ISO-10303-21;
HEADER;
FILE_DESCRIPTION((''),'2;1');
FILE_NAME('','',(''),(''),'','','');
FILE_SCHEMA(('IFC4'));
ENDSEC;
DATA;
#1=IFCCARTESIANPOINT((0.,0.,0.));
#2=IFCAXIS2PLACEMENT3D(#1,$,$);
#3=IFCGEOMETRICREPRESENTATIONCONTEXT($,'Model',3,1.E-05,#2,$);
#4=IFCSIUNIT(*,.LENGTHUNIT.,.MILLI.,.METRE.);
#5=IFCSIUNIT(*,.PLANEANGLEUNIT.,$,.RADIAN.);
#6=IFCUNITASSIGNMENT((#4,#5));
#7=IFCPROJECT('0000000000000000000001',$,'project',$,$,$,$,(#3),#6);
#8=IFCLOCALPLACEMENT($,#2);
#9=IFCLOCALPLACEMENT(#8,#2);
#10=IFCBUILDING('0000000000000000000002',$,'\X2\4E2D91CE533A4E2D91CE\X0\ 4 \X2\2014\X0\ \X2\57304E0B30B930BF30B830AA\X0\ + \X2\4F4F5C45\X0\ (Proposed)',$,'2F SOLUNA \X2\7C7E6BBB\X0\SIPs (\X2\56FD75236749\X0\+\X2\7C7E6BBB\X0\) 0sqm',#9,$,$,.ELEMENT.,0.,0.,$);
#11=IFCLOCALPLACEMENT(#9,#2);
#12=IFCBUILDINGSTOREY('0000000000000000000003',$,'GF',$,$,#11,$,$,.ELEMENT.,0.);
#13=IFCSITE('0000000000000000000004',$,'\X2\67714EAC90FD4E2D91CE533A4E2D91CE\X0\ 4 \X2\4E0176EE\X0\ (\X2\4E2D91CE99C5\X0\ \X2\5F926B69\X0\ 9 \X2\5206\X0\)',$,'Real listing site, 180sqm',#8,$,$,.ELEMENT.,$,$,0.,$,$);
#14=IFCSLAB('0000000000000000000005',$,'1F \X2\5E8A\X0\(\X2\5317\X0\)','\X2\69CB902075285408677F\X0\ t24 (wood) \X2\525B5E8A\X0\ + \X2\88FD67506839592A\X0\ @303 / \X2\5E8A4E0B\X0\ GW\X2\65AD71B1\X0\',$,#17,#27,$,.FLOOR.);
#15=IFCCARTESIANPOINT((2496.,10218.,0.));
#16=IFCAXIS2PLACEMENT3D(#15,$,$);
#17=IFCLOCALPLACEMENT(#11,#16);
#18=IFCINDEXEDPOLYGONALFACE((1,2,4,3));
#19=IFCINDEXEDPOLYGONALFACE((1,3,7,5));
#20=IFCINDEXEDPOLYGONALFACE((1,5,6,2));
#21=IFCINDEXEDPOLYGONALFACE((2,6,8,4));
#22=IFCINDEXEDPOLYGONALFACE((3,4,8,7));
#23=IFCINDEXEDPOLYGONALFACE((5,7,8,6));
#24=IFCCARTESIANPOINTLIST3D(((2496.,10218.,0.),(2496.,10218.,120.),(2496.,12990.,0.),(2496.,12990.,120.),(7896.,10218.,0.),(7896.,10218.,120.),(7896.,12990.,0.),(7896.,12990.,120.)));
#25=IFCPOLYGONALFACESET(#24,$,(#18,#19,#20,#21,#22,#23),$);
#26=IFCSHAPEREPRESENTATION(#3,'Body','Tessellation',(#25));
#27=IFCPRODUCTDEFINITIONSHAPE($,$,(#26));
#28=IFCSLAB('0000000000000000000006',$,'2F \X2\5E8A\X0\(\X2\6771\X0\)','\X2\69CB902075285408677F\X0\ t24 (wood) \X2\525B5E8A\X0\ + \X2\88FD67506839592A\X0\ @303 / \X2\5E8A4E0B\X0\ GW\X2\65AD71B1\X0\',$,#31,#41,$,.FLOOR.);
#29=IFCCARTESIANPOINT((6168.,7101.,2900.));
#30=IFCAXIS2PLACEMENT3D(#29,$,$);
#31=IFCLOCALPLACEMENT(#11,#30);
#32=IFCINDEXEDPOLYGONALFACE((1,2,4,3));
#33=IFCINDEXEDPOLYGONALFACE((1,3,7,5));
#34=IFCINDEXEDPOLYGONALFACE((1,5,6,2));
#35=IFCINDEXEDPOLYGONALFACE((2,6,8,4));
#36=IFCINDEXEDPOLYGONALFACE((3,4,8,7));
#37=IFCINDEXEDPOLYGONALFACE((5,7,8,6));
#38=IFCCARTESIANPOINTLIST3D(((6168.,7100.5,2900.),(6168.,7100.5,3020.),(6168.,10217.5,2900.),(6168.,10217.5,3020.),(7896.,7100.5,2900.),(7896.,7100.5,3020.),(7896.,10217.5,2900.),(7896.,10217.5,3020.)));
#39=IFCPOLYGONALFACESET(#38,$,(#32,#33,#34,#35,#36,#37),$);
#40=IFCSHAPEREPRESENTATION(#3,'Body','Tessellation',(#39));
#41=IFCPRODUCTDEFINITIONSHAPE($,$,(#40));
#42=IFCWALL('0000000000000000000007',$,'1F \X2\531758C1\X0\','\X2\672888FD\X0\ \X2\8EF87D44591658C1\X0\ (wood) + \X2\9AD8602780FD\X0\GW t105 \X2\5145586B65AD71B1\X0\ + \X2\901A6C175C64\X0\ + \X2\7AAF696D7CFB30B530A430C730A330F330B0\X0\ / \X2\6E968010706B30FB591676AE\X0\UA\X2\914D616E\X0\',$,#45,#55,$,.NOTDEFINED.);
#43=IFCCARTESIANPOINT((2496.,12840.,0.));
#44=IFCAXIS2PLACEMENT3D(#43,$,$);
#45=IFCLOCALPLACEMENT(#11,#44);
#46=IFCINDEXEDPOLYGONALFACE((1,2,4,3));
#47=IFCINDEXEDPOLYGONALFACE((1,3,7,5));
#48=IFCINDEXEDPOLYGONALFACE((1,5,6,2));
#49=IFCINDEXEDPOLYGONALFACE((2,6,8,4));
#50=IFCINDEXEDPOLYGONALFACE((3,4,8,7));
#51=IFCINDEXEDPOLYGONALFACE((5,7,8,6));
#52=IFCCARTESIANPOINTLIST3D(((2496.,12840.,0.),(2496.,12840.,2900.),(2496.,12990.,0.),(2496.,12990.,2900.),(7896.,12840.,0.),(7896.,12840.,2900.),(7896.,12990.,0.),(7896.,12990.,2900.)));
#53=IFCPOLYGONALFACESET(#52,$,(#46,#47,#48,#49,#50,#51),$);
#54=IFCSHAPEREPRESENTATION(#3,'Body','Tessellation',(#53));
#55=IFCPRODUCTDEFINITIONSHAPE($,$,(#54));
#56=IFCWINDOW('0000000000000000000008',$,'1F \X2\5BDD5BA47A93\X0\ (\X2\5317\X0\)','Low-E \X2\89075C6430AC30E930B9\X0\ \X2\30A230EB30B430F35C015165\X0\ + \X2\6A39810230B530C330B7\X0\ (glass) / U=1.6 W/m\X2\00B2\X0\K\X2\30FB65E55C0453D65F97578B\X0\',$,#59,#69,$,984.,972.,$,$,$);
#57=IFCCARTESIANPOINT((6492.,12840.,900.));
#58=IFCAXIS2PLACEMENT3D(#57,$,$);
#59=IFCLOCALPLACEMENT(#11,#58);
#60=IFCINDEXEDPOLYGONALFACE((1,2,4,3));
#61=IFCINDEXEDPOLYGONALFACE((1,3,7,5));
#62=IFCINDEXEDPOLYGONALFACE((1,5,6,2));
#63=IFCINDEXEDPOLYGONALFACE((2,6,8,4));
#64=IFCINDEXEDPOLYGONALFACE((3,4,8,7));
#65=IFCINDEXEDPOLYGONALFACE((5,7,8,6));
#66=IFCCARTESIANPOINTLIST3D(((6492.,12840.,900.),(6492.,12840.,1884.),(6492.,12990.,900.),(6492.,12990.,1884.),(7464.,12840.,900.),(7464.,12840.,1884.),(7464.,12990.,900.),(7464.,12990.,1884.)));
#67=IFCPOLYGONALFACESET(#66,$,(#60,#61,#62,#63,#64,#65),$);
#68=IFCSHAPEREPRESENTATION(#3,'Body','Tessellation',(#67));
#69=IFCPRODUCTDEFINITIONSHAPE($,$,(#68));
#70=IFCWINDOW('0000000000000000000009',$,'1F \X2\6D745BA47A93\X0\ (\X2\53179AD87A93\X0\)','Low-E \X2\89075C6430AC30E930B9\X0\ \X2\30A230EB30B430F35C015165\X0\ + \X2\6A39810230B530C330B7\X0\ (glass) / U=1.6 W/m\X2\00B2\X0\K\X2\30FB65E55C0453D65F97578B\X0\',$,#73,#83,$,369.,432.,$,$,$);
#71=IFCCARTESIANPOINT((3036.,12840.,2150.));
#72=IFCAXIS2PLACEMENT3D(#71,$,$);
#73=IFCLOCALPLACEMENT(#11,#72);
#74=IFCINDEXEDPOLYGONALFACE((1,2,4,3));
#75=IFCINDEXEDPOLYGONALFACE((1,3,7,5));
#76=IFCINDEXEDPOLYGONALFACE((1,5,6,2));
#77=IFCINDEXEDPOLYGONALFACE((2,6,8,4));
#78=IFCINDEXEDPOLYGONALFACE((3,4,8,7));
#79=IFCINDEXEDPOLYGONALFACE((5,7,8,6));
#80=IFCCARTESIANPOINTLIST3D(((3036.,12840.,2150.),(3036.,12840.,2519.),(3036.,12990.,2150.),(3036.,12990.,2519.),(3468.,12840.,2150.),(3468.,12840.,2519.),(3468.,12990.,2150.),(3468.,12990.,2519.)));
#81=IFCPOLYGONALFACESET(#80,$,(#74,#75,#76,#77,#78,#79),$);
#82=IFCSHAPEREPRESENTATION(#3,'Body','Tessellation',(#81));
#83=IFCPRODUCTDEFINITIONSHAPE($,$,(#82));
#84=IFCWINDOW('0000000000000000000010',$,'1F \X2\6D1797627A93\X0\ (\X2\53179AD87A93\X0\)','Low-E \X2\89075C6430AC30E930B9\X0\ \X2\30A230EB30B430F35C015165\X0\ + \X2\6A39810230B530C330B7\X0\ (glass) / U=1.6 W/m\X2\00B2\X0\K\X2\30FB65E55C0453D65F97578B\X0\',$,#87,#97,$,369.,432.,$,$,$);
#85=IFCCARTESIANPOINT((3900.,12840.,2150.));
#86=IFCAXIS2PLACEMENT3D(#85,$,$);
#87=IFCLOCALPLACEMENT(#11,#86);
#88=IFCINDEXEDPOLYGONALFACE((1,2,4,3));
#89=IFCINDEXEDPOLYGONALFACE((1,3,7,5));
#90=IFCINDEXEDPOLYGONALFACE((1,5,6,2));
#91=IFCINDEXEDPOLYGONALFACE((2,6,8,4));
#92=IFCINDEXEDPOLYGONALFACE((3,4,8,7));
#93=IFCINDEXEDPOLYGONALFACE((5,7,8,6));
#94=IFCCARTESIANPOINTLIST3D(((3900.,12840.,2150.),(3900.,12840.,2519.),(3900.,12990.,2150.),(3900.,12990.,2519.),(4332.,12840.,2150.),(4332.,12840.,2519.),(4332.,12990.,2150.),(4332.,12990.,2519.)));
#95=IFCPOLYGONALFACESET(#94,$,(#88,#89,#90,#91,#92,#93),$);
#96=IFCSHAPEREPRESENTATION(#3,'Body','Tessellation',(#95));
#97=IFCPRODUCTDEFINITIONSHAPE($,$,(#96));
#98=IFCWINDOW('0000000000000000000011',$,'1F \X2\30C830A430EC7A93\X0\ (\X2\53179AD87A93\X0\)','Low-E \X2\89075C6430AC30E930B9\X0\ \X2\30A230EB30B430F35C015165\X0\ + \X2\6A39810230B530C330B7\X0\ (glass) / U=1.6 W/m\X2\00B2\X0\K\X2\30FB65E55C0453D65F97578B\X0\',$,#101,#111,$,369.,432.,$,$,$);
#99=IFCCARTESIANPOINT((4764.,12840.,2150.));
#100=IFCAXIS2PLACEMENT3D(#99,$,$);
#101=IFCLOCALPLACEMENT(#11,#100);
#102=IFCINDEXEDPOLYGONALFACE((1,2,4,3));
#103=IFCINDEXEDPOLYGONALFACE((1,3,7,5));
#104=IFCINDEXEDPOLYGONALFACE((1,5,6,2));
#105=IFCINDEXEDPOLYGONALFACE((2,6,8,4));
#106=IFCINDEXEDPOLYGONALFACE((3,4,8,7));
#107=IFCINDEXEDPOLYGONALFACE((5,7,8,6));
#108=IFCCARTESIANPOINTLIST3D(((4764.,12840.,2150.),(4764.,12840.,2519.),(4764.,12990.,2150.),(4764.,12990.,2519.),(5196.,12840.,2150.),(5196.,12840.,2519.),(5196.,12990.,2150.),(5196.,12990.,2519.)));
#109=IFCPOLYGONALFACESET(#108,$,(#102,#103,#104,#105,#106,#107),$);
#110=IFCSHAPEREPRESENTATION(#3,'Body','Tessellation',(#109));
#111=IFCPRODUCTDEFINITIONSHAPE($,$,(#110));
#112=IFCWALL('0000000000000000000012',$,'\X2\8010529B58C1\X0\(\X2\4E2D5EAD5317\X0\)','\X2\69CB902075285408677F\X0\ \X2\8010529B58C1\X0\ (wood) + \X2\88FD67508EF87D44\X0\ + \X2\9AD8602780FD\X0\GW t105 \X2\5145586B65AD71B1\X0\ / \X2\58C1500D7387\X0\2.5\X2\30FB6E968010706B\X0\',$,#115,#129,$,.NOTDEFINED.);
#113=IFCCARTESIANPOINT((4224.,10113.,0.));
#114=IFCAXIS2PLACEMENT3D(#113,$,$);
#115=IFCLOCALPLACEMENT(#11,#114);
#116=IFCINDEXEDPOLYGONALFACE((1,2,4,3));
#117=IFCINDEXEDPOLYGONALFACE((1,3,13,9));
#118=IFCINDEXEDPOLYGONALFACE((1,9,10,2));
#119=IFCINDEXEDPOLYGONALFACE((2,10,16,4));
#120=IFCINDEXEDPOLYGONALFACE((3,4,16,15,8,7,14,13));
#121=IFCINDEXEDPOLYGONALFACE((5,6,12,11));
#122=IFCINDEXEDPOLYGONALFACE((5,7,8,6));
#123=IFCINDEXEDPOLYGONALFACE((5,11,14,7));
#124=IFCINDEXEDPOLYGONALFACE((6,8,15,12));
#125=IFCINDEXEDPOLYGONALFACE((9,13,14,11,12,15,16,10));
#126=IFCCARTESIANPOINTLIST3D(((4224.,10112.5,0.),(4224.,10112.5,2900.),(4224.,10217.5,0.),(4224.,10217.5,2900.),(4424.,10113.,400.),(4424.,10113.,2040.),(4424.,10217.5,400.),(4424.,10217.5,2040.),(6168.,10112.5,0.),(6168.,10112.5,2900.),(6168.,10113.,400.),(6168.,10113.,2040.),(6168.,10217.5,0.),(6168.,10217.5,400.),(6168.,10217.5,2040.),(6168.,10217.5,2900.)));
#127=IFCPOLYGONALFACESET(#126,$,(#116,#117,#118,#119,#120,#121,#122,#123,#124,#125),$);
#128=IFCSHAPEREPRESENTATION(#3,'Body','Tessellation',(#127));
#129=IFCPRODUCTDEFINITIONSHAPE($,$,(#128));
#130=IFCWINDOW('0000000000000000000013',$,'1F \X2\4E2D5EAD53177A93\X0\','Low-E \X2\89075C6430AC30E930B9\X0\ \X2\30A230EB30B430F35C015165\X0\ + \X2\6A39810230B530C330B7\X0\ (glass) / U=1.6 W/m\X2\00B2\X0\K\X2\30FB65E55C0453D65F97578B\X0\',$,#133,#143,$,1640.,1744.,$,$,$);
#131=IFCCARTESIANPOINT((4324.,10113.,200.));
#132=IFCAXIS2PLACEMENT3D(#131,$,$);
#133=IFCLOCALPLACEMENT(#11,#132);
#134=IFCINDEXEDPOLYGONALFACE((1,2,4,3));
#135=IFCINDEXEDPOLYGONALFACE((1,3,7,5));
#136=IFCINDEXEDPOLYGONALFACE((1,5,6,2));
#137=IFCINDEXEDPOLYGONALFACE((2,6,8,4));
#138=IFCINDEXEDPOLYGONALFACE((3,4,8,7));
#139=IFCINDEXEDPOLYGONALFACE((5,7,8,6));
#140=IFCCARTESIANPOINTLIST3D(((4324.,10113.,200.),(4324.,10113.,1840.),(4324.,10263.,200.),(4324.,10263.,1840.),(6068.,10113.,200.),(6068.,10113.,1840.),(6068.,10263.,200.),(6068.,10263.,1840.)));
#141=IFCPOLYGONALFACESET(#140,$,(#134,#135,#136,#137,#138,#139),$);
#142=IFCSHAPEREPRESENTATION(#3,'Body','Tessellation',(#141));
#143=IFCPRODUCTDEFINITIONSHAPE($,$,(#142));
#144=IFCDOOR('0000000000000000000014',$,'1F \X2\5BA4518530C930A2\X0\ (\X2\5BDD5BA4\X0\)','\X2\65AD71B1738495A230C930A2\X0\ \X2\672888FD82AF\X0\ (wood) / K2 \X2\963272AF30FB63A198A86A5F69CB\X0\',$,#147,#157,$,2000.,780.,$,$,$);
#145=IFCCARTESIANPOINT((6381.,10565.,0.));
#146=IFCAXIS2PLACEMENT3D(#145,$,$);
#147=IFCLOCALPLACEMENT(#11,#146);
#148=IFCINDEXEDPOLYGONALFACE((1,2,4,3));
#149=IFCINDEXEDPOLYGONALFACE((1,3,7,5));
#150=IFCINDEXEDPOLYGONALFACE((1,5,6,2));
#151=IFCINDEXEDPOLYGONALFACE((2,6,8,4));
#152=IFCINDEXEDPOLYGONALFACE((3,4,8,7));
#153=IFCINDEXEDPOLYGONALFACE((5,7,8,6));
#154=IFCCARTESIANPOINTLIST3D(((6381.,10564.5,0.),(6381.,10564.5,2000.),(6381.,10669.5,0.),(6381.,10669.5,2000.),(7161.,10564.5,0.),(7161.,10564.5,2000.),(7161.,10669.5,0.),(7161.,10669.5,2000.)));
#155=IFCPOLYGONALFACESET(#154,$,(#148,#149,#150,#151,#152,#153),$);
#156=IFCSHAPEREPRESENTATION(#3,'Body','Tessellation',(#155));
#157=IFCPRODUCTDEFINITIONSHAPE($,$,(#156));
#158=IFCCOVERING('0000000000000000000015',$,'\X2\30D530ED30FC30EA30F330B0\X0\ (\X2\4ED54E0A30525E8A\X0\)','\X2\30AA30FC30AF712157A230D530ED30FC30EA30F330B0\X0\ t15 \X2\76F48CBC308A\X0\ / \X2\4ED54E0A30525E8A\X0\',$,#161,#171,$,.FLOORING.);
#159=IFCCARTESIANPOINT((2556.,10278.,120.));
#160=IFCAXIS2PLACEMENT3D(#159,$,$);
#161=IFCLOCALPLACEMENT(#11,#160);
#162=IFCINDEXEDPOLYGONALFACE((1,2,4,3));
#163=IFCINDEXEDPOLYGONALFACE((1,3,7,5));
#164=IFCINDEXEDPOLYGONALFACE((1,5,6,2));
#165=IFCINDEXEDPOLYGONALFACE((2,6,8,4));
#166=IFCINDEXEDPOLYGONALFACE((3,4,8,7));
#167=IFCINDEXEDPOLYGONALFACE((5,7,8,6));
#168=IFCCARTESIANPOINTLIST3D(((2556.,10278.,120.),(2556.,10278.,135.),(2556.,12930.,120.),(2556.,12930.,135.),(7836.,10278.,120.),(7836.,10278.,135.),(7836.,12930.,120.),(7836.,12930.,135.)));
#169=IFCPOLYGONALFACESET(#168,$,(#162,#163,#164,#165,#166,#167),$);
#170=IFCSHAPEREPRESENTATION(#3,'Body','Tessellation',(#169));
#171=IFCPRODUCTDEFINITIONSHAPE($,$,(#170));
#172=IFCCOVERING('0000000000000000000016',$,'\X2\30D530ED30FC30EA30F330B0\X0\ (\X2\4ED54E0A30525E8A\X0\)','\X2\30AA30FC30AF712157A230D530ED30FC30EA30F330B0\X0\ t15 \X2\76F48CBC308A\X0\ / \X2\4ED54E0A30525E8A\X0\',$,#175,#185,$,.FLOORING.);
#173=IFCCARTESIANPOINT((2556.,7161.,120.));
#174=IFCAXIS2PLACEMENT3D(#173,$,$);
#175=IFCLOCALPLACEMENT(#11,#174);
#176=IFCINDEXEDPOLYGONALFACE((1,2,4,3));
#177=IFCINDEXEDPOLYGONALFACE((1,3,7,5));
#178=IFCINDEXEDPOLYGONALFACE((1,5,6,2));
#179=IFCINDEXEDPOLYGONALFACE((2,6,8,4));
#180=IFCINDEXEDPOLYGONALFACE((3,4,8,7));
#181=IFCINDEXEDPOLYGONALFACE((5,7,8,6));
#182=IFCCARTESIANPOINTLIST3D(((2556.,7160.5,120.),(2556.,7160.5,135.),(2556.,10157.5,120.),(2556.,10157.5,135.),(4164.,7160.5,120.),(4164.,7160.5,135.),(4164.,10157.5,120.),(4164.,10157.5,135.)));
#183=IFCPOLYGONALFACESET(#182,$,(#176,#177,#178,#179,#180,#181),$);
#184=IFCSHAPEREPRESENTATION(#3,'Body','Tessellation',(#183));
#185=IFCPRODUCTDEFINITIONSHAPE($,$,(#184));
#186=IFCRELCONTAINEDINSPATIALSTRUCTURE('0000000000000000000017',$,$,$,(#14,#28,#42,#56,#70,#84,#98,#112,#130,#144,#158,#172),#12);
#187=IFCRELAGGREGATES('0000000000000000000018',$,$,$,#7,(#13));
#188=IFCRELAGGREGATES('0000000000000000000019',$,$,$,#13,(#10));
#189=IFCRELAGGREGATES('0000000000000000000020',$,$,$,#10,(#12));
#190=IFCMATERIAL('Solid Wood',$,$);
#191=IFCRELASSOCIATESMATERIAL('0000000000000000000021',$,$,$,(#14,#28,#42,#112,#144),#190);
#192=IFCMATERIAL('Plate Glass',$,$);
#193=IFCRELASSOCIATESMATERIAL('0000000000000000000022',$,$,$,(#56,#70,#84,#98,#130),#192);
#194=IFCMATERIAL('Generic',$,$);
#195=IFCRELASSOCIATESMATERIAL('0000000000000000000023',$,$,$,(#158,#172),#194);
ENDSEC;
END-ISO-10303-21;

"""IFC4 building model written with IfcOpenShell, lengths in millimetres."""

from ifc_helpers import new_model, si_unit, frame, frame_2d, origin, place, context, project, spatial, rectangle, extrude, material, element, fill, save


model = new_model("IFC4")

# Units and contexts
model_context = context("Model", 3, precision=1e-05, world=origin())
ifc_project = project(units=[si_unit("LENGTHUNIT", "METRE", prefix="MILLI"), si_unit("PLANEANGLEUNIT", "RADIAN")], contexts=[model_context])

# Site, building, storey
site_placement = place(None, origin())
site = spatial("IfcSite", under=ifc_project, at=site_placement, Name="東京都中野区中野 4 丁目 (中野駅 徒歩 9 分)", ObjectType="Real listing site, 180sqm", CompositionType="ELEMENT", RefElevation=0.0)
building_placement = place(site_placement, origin())
building = spatial("IfcBuilding", under=site, at=building_placement, Name="中野区中野 4 — 地下スタジオ + 住居 (Proposed)", ObjectType="2F SOLUNA 籾殻SIPs (国産杉+籾殻) 0sqm", CompositionType="ELEMENT", ElevationOfRefHeight=0.0, ElevationOfTerrain=0.0)
storey_placement = place(building_placement, origin())
storey = spatial("IfcBuildingStorey", under=building, at=storey_placement, Name="GF", CompositionType="ELEMENT", Elevation=0.0)

# Slabs
ifc_material_1 = material(Name="Solid Wood")
slab_1_placement = place(storey_placement, frame((2496.0, 10218.0, 0.0)))
element("IfcSlab", 1, at=slab_1_placement, inside=storey, material=ifc_material_1, Name="1F 床(北)", Description="構造用合板 t24 (wood) 剛床 + 製材根太 @303 / 床下 GW断熱", PredefinedType="FLOOR", context=model_context, shape_type="SweptSolid", body=[
    extrude(rectangle(XDim=5400.0, YDim=2772.0, at=frame_2d((2700.0, 1386.0))), frame((2496.0, 10218.0, 0.0)), (0.0, 0.0, 1.0), 120.0),
])
slab_2_placement = place(storey_placement, frame((6168.0, 7101.0, 2900.0)))
element("IfcSlab", 2, at=slab_2_placement, inside=storey, material=ifc_material_1, Name="2F 床(東)", Description="構造用合板 t24 (wood) 剛床 + 製材根太 @303 / 床下 GW断熱", PredefinedType="FLOOR", context=model_context, shape_type="SweptSolid", body=[
    extrude(rectangle(XDim=1728.0, YDim=3117.0, at=frame_2d((864.0, 1558.0))), frame((6168.0, 7101.0, 2900.0)), (0.0, 0.0, 1.0), 120.0),
])

# Wall, openings, windows
wall_1_placement = place(storey_placement, frame((2496.0, 12840.0, 0.0)))
wall_1 = element("IfcWall", 3, at=wall_1_placement, inside=storey, material=ifc_material_1, Name="1F 北壁", Description="木製 軸組外壁 (wood) + 高性能GW t105 充填断熱 + 通気層 + 窯業系サイディング / 準耐火・外皮UA配慮", PredefinedType="NOTDEFINED", context=model_context, shape_type="SweptSolid", body=[
    extrude(rectangle(XDim=5400.0, YDim=150.0, at=frame_2d((2700.0, 75.0))), frame((2496.0, 12840.0, 0.0)), (0.0, 0.0, 1.0), 2900.0),
])
opening_1_placement = place(storey_placement, frame((6492.0, 12840.0, 900.0)))
opening_1 = element("IfcOpeningElement", 4, at=opening_1_placement, cuts=wall_1, PredefinedType="NOTDEFINED", context=model_context, shape_type="SweptSolid", body=[
    extrude(rectangle(XDim=972.0, YDim=150.0, at=frame_2d((486.0, 75.0))), frame((6492.0, 12840.0, 900.0)), (0.0, 0.0, 1.0), 984.0),
])
opening_2_placement = place(storey_placement, frame((3036.0, 12840.0, 2150.0)))
opening_2 = element("IfcOpeningElement", 5, at=opening_2_placement, cuts=wall_1, PredefinedType="NOTDEFINED", context=model_context, shape_type="SweptSolid", body=[
    extrude(rectangle(XDim=432.0, YDim=150.0, at=frame_2d((216.0, 75.0))), frame((3036.0, 12840.0, 2150.0)), (0.0, 0.0, 1.0), 369.0),
])
opening_3_placement = place(storey_placement, frame((3900.0, 12840.0, 2150.0)))
opening_3 = element("IfcOpeningElement", 6, at=opening_3_placement, cuts=wall_1, PredefinedType="NOTDEFINED", context=model_context, shape_type="SweptSolid", body=[
    extrude(rectangle(XDim=432.0, YDim=150.0, at=frame_2d((216.0, 75.0))), frame((3900.0, 12840.0, 2150.0)), (0.0, 0.0, 1.0), 369.0),
])
opening_4_placement = place(storey_placement, frame((4764.0, 12840.0, 2150.0)))
opening_4 = element("IfcOpeningElement", 7, at=opening_4_placement, cuts=wall_1, PredefinedType="NOTDEFINED", context=model_context, shape_type="SweptSolid", body=[
    extrude(rectangle(XDim=432.0, YDim=150.0, at=frame_2d((216.0, 75.0))), frame((4764.0, 12840.0, 2150.0)), (0.0, 0.0, 1.0), 369.0),
])
ifc_material_2 = material(Name="Plate Glass")
window_1_placement = place(storey_placement, frame((6492.0, 12840.0, 900.0)))
window_1 = element("IfcWindow", 8, at=window_1_placement, inside=storey, material=ifc_material_2, Name="1F 寝室窓 (北)", Description="Low-E 複層ガラス アルゴン封入 + 樹脂サッシ (glass) / U=1.6 W/m²K・日射取得型", OverallHeight=984.0, OverallWidth=972.0, context=model_context, shape_type="SweptSolid", body=[
    extrude(rectangle(XDim=972.0, YDim=150.0, at=frame_2d((486.0, 75.0))), frame((6492.0, 12840.0, 900.0)), (0.0, 0.0, 1.0), 984.0),
])
fill(opening_1, window_1)
window_2_placement = place(storey_placement, frame((3036.0, 12840.0, 2150.0)))
window_2 = element("IfcWindow", 9, at=window_2_placement, inside=storey, material=ifc_material_2, Name="1F 浴室窓 (北高窓)", Description="Low-E 複層ガラス アルゴン封入 + 樹脂サッシ (glass) / U=1.6 W/m²K・日射取得型", OverallHeight=369.0, OverallWidth=432.0, context=model_context, shape_type="SweptSolid", body=[
    extrude(rectangle(XDim=432.0, YDim=150.0, at=frame_2d((216.0, 75.0))), frame((3036.0, 12840.0, 2150.0)), (0.0, 0.0, 1.0), 369.0),
])
fill(opening_2, window_2)
window_3_placement = place(storey_placement, frame((3900.0, 12840.0, 2150.0)))
window_3 = element("IfcWindow", 10, at=window_3_placement, inside=storey, material=ifc_material_2, Name="1F 洗面窓 (北高窓)", Description="Low-E 複層ガラス アルゴン封入 + 樹脂サッシ (glass) / U=1.6 W/m²K・日射取得型", OverallHeight=369.0, OverallWidth=432.0, context=model_context, shape_type="SweptSolid", body=[
    extrude(rectangle(XDim=432.0, YDim=150.0, at=frame_2d((216.0, 75.0))), frame((3900.0, 12840.0, 2150.0)), (0.0, 0.0, 1.0), 369.0),
])
fill(opening_3, window_3)
window_4_placement = place(storey_placement, frame((4764.0, 12840.0, 2150.0)))
window_4 = element("IfcWindow", 11, at=window_4_placement, inside=storey, material=ifc_material_2, Name="1F トイレ窓 (北高窓)", Description="Low-E 複層ガラス アルゴン封入 + 樹脂サッシ (glass) / U=1.6 W/m²K・日射取得型", OverallHeight=369.0, OverallWidth=432.0, context=model_context, shape_type="SweptSolid", body=[
    extrude(rectangle(XDim=432.0, YDim=150.0, at=frame_2d((216.0, 75.0))), frame((4764.0, 12840.0, 2150.0)), (0.0, 0.0, 1.0), 369.0),
])
fill(opening_4, window_4)

# Wall, opening, window
wall_2_placement = place(storey_placement, frame((4224.0, 10113.0, 0.0)))
wall_2 = element("IfcWall", 12, at=wall_2_placement, inside=storey, material=ifc_material_1, Name="耐力壁(中庭北)", Description="構造用合板 耐力壁 (wood) + 製材軸組 + 高性能GW t105 充填断熱 / 壁倍率2.5・準耐火", PredefinedType="NOTDEFINED", context=model_context, shape_type="SweptSolid", body=[
    extrude(rectangle(XDim=1944.0, YDim=105.0, at=frame_2d((972.0, 52.0))), frame((4224.0, 10113.0, 0.0)), (0.0, 0.0, 1.0), 2900.0),
])
opening_5_placement = place(storey_placement, frame((4324.0, 10113.0, 200.0)))
opening_5 = element("IfcOpeningElement", 13, at=opening_5_placement, cuts=wall_2, PredefinedType="NOTDEFINED", context=model_context, shape_type="SweptSolid", body=[
    extrude(rectangle(XDim=1744.0, YDim=150.0, at=frame_2d((872.0, 75.0))), frame((4324.0, 10113.0, 200.0)), (0.0, 0.0, 1.0), 1640.0),
])
window_5_placement = place(storey_placement, frame((4324.0, 10113.0, 200.0)))
window_5 = element("IfcWindow", 14, at=window_5_placement, inside=storey, material=ifc_material_2, Name="1F 中庭北窓", Description="Low-E 複層ガラス アルゴン封入 + 樹脂サッシ (glass) / U=1.6 W/m²K・日射取得型", OverallHeight=1640.0, OverallWidth=1744.0, context=model_context, shape_type="SweptSolid", body=[
    extrude(rectangle(XDim=1744.0, YDim=150.0, at=frame_2d((872.0, 75.0))), frame((4324.0, 10113.0, 200.0)), (0.0, 0.0, 1.0), 1640.0),
])
fill(opening_5, window_5)

# Door
door_1_placement = place(storey_placement, frame((6381.0, 10565.0, 0.0)))
element("IfcDoor", 15, at=door_1_placement, inside=storey, material=ifc_material_1, Name="1F 室内ドア (寝室)", Description="断熱玄関ドア 木製芯 (wood) / K2 防犯・採風機構", OverallHeight=2000.0, OverallWidth=780.0, context=model_context, shape_type="SweptSolid", body=[
    extrude(rectangle(XDim=780.0, YDim=105.0, at=frame_2d((390.0, 52.0))), frame((6381.0, 10565.0, 0.0)), (0.0, 0.0, 1.0), 2000.0),
])

# Coverings
ifc_material_3 = material(Name="Generic")
covering_1_placement = place(storey_placement, frame((2556.0, 10278.0, 120.0)))
element("IfcCovering", 16, at=covering_1_placement, inside=storey, material=ifc_material_3, Name="フローリング (仕上げ床)", Description="オーク無垢フローリング t15 直貼り / 仕上げ床", PredefinedType="FLOORING", context=model_context, shape_type="SweptSolid", body=[
    extrude(rectangle(XDim=5280.0, YDim=2652.0, at=frame_2d((2640.0, 1326.0))), frame((2556.0, 10278.0, 120.0)), (0.0, 0.0, 1.0), 15.0),
])
covering_2_placement = place(storey_placement, frame((2556.0, 7161.0, 120.0)))
element("IfcCovering", 17, at=covering_2_placement, inside=storey, material=ifc_material_3, Name="フローリング (仕上げ床)", Description="オーク無垢フローリング t15 直貼り / 仕上げ床", PredefinedType="FLOORING", context=model_context, shape_type="SweptSolid", body=[
    extrude(rectangle(XDim=1608.0, YDim=2997.0, at=frame_2d((804.0, 1498.0))), frame((2556.0, 7161.0, 120.0)), (0.0, 0.0, 1.0), 15.0),
])

save(model, "model.ifc")
